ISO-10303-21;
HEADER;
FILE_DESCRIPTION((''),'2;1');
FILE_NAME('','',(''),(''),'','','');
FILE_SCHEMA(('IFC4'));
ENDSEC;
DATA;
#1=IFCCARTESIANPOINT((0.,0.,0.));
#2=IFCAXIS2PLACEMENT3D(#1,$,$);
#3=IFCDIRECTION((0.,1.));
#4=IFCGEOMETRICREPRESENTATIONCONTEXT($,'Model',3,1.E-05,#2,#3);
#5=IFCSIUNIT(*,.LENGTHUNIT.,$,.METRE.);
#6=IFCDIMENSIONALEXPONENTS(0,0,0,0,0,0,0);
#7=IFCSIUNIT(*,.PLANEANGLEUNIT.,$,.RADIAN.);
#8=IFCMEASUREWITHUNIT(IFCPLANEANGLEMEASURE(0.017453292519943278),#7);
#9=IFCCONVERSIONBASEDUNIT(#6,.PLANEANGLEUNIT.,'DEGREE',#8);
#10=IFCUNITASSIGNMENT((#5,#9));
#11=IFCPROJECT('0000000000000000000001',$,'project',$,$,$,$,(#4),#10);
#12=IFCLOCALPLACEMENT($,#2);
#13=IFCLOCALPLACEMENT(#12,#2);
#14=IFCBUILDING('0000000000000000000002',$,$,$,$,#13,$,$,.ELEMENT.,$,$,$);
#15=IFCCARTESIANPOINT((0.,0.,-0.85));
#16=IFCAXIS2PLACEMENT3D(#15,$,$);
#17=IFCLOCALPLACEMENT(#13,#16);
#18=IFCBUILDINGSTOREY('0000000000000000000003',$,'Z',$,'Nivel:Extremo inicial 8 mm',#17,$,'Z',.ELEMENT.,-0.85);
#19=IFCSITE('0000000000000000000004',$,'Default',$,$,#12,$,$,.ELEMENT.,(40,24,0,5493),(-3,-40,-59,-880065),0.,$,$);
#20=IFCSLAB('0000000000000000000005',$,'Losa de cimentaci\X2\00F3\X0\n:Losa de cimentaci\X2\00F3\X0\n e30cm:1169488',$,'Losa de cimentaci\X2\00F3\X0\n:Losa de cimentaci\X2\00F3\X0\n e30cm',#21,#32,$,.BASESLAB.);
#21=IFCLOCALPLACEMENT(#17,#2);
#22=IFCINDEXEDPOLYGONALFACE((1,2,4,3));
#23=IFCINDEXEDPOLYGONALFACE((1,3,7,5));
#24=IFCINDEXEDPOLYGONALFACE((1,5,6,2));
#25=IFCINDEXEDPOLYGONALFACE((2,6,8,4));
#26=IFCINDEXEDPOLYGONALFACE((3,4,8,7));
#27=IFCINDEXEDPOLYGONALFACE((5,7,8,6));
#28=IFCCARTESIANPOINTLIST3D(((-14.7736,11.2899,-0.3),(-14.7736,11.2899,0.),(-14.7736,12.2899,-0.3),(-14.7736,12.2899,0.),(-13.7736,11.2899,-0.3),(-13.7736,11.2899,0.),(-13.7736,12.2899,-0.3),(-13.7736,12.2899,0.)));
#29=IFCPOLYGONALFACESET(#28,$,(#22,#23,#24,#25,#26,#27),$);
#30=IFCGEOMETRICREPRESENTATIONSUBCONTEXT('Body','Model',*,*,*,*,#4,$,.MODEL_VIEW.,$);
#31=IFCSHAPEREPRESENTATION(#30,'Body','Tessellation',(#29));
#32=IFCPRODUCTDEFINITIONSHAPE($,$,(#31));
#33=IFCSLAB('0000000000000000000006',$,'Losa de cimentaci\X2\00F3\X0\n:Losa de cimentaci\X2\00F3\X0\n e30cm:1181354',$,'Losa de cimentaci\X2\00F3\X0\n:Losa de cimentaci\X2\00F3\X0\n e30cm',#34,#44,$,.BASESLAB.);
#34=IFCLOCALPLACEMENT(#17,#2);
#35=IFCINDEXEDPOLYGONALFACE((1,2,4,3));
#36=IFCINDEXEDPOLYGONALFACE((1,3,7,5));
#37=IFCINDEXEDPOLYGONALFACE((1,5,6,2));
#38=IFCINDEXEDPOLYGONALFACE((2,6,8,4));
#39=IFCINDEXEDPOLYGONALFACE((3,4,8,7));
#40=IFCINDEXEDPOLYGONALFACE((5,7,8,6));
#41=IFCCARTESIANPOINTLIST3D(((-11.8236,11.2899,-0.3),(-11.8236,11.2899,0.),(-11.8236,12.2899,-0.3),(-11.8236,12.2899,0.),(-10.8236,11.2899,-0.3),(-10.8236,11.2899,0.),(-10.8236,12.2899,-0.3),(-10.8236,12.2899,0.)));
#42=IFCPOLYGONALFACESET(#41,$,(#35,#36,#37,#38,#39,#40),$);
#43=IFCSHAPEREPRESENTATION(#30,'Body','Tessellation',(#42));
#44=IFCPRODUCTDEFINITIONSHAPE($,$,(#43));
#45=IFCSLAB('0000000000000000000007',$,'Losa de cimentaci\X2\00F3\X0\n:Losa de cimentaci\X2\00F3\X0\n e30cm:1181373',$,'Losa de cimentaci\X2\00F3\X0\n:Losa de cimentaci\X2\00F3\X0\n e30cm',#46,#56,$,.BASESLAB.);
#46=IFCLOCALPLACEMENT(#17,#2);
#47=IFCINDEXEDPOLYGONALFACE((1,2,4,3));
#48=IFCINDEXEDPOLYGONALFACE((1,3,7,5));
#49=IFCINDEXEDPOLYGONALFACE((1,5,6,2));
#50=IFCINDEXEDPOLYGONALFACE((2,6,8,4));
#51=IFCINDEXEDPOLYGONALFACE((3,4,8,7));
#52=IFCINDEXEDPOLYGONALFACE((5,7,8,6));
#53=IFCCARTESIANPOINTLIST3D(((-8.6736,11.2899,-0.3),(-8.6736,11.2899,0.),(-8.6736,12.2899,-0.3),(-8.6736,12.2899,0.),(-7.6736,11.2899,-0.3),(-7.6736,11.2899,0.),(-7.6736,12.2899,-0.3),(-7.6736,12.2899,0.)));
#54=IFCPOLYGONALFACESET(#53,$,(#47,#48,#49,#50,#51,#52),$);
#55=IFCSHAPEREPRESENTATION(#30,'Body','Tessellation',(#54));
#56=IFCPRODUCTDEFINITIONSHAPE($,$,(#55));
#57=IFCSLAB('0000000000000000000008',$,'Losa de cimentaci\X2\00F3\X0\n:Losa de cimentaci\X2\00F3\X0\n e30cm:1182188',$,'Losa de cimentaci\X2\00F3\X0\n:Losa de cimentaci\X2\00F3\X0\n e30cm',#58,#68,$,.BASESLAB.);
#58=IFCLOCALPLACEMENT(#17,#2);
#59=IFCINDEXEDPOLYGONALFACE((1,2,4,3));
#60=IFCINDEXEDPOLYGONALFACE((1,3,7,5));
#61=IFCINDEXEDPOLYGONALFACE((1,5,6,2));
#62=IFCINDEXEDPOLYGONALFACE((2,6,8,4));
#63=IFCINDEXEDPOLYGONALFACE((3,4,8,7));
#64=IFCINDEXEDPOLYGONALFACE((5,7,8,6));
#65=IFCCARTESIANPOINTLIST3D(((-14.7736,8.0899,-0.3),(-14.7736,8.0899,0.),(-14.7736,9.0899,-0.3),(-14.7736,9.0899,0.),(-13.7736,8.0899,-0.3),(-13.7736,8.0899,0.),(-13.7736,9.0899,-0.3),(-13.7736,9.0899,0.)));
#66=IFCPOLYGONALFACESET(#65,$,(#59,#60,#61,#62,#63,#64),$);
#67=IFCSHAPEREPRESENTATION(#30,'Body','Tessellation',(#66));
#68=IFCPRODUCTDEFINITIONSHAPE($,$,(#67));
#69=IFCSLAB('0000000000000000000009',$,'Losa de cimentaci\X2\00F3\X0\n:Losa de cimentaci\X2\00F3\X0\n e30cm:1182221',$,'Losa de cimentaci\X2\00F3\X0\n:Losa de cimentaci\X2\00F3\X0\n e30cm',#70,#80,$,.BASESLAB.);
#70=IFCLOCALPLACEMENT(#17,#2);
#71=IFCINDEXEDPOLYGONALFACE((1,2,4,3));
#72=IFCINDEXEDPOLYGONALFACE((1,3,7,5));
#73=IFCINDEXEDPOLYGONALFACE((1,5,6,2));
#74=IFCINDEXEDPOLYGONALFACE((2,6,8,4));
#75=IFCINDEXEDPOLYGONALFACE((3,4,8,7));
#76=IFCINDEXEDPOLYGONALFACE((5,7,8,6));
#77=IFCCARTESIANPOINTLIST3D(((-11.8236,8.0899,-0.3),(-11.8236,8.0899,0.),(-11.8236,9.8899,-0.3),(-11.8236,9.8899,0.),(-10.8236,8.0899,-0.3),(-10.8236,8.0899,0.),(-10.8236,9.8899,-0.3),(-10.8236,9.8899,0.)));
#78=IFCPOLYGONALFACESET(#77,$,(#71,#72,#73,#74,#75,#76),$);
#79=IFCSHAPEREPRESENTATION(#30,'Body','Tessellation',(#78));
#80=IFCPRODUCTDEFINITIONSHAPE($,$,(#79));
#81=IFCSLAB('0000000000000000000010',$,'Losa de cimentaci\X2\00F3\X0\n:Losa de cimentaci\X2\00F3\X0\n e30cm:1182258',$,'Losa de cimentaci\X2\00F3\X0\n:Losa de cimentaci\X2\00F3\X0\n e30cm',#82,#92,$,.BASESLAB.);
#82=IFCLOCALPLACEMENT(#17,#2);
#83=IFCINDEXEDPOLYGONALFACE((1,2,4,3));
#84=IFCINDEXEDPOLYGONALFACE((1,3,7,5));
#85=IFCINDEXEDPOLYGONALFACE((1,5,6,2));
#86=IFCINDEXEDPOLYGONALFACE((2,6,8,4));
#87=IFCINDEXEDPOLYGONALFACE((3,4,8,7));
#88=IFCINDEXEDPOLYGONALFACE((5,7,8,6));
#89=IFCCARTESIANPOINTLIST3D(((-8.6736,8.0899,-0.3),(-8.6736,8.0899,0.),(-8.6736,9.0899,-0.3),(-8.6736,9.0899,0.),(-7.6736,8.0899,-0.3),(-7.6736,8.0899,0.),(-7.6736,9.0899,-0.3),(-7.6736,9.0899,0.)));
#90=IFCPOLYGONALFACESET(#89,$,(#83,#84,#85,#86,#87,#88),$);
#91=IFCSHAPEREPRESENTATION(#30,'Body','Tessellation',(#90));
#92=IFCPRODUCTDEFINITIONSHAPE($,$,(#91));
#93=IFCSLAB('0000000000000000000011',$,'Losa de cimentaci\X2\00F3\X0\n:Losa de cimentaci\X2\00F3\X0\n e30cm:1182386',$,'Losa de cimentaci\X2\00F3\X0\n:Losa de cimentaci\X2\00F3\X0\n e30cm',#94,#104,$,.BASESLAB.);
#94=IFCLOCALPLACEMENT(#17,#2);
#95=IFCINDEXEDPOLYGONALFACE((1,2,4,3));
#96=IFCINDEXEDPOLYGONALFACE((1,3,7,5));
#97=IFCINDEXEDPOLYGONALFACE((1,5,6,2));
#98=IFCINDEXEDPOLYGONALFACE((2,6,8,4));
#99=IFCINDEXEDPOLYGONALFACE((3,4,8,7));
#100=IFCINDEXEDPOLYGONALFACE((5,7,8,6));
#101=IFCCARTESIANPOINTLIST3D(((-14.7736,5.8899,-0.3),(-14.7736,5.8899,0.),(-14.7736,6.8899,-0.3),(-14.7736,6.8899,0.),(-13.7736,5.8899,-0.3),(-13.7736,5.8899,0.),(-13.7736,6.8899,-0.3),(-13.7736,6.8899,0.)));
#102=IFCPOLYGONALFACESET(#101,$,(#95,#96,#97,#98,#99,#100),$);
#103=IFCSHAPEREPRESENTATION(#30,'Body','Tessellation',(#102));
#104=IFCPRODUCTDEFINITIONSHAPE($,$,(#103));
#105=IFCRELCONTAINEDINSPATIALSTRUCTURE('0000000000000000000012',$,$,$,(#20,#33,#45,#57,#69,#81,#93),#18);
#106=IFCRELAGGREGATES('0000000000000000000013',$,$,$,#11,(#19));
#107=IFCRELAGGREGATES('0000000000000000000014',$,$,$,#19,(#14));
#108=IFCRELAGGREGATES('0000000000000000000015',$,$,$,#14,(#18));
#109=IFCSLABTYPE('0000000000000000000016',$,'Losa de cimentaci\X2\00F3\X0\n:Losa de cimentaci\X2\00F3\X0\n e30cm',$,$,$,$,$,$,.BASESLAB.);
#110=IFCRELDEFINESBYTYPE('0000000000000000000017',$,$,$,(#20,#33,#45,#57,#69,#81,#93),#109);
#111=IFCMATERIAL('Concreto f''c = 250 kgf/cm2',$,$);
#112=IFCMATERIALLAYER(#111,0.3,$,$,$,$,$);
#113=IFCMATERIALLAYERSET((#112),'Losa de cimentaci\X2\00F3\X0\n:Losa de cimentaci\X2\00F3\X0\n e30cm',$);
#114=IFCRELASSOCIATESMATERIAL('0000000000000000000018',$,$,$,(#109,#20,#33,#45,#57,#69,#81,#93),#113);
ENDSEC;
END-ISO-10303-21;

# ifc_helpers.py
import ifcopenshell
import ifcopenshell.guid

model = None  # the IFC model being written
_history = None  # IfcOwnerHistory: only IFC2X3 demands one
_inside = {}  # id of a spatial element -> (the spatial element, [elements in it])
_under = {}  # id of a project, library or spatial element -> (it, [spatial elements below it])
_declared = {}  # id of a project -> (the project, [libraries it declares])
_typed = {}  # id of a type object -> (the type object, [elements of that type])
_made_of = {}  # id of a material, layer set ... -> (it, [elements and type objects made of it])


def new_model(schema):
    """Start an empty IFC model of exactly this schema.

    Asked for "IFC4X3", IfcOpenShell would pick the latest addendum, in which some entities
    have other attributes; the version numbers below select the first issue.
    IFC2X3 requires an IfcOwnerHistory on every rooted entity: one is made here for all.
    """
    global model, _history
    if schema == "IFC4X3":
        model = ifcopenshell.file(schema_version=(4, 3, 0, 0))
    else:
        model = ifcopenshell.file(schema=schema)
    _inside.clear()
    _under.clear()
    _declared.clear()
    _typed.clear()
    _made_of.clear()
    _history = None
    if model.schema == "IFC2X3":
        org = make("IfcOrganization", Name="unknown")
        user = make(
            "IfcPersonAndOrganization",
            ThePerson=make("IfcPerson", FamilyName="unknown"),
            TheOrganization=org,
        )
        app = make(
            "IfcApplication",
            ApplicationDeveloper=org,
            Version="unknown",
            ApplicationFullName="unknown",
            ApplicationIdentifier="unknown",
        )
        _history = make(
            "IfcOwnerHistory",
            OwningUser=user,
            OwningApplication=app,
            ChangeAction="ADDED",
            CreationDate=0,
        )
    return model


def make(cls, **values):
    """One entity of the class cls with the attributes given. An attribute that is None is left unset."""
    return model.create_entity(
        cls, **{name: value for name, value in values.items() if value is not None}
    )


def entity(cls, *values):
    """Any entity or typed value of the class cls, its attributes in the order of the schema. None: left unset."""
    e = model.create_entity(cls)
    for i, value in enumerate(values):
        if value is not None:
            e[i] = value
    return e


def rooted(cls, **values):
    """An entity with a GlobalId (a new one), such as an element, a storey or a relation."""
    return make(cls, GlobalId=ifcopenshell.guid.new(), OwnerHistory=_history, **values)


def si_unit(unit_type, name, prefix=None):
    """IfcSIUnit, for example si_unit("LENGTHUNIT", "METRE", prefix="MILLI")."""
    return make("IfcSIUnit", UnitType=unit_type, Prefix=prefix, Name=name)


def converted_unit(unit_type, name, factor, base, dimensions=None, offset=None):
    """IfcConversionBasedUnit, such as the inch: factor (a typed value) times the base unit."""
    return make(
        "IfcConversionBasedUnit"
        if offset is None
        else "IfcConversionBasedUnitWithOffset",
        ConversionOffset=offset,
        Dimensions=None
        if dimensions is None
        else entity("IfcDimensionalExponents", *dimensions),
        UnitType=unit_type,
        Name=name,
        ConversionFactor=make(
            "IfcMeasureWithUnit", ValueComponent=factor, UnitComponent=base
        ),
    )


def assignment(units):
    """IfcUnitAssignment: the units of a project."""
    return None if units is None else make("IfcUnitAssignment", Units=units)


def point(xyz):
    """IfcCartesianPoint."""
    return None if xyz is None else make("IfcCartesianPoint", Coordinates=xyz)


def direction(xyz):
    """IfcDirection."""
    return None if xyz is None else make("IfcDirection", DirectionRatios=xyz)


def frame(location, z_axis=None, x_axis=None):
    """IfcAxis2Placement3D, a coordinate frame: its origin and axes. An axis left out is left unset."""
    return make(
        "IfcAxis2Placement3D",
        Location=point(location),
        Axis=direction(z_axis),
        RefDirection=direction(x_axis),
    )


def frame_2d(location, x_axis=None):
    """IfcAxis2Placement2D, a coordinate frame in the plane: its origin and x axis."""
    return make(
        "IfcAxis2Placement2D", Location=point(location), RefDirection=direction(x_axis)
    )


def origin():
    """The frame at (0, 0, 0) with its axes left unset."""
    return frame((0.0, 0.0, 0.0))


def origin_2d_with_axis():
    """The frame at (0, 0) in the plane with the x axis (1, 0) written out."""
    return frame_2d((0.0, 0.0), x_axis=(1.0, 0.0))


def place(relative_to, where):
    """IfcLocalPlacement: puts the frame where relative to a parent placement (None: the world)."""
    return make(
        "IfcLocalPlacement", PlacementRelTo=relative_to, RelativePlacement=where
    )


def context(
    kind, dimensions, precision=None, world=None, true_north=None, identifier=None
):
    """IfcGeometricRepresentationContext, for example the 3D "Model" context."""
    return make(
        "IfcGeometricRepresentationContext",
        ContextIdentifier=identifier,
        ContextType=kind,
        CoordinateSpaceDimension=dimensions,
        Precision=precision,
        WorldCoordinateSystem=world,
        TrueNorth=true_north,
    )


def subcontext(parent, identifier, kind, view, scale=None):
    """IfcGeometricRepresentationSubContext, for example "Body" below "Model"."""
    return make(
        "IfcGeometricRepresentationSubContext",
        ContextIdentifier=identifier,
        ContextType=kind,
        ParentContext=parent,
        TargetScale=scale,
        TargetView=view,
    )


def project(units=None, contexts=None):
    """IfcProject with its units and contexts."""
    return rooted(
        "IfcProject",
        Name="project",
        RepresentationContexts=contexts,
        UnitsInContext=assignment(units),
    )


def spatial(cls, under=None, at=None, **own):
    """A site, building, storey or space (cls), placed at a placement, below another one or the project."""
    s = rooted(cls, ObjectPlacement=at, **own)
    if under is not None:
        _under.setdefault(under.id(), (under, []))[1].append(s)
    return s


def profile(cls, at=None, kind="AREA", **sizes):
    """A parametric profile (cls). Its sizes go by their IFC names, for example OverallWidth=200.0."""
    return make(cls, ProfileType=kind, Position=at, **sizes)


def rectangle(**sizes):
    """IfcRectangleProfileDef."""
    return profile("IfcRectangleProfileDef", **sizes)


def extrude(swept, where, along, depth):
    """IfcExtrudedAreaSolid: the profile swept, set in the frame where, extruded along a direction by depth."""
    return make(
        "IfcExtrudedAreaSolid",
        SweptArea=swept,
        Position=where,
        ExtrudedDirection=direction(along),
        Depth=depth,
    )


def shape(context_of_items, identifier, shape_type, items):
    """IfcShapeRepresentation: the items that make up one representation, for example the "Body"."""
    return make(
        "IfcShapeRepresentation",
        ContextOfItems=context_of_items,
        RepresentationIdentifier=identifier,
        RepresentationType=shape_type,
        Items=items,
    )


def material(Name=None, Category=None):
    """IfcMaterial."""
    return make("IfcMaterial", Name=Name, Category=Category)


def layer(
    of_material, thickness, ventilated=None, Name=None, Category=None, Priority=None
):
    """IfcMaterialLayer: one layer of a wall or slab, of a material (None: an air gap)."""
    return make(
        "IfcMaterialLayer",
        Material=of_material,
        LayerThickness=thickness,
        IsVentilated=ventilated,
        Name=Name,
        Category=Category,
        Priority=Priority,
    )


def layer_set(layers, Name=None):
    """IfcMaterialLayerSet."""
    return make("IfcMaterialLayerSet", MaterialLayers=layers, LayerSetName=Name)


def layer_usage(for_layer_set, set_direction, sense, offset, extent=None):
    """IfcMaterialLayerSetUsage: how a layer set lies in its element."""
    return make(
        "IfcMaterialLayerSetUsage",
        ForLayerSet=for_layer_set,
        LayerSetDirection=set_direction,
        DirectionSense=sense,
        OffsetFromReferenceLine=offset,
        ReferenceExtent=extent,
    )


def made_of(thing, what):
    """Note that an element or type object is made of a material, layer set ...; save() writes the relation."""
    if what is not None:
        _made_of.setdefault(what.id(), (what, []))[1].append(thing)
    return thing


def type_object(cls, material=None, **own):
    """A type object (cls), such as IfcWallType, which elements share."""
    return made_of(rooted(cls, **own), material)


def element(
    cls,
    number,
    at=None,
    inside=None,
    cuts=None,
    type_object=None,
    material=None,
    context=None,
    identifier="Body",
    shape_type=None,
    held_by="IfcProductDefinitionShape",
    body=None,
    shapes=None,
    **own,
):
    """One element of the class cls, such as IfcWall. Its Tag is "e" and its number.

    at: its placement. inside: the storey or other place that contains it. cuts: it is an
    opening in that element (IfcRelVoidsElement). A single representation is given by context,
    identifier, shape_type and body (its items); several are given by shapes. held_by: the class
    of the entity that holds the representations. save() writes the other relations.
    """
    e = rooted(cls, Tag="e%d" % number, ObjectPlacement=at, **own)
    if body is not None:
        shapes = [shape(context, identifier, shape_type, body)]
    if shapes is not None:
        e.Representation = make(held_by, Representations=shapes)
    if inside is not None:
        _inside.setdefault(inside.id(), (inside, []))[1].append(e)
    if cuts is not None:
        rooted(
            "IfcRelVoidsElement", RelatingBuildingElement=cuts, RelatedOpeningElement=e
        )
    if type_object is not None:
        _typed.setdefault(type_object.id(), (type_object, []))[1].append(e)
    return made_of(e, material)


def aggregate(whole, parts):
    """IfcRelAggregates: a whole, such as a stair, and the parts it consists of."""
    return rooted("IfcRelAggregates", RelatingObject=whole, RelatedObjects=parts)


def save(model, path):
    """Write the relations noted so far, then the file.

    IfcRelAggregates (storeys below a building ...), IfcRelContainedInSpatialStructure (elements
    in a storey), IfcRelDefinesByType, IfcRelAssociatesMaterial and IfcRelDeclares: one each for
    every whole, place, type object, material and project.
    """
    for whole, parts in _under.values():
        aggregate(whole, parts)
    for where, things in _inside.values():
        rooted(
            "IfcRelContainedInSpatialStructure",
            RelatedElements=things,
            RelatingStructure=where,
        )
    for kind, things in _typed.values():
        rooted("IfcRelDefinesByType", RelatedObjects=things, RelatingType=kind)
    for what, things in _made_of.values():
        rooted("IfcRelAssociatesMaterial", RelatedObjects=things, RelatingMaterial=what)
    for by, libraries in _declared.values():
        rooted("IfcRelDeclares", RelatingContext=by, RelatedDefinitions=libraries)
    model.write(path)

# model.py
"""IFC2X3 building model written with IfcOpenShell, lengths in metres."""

from ifc_helpers import new_model, entity, si_unit, converted_unit, direction, frame, frame_2d, origin, origin_2d_with_axis, place, context, subcontext, project, spatial, rectangle, extrude, material, layer, layer_set, layer_usage, type_object, element, save


model = new_model("IFC2X3")

# Units and contexts
model_context = context("Model", 3, precision=1e-05, world=origin(), true_north=direction((0.0, 1.0)))
body_context = subcontext(model_context, "Body", "Model", "MODEL_VIEW")
ifc_project = project(units=[si_unit("LENGTHUNIT", "METRE"), converted_unit("PLANEANGLEUNIT", "DEGREE", entity("IfcPlaneAngleMeasure", 0.017453292519943278), si_unit("PLANEANGLEUNIT", "RADIAN"), dimensions=[0, 0, 0, 0, 0, 0, 0])], contexts=[model_context])

# Site, building, storey
site_placement = place(None, origin())
site = spatial("IfcSite", under=ifc_project, at=site_placement, Name="Default", CompositionType="ELEMENT", RefLatitude=(40, 24, 0, 5493), RefLongitude=(-3, -40, -59, -880065), RefElevation=0.0)
building_placement = place(site_placement, origin())
building = spatial("IfcBuilding", under=site, at=building_placement, CompositionType="ELEMENT")
storey_placement = place(building_placement, frame((0.0, 0.0, -0.85)))
storey = spatial("IfcBuildingStorey", under=building, at=storey_placement, Name="Z", ObjectType="Nivel:Extremo inicial 8 mm", LongName="Z", CompositionType="ELEMENT", Elevation=-0.85)

# Slabs
ifc_material_1 = material(Name="Concreto f'c = 250 kgf/cm2")
ifc_layer = layer(ifc_material_1, 0.3)
ifc_layer_set = layer_set([ifc_layer], Name="Losa de cimentación:Losa de cimentación e30cm")
ifc_layer_usage_1 = layer_usage(ifc_layer_set, "AXIS3", "POSITIVE", 0.0)
slab_type = type_object("IfcSlabType", Name="Losa de cimentación:Losa de cimentación e30cm", PredefinedType="BASESLAB", material=ifc_layer_set)
slab_1_placement = place(storey_placement, origin())
element("IfcSlab", 1, at=slab_1_placement, inside=storey, type_object=slab_type, material=ifc_layer_usage_1, Name="Losa de cimentación:Losa de cimentación e30cm:1169488", ObjectType="Losa de cimentación:Losa de cimentación e30cm", PredefinedType="BASESLAB", context=body_context, shape_type="SweptSolid", body=[
    extrude(rectangle(XDim=1.0, YDim=1.0, at=origin_2d_with_axis()), frame((-14.2736, 11.7899, 0.0), z_axis=(0.0, 0.0, -1.0), x_axis=(0.0, 1.0, 0.0)), (0.0, 0.0, 1.0), 0.3),
])
ifc_layer_usage_2 = layer_usage(ifc_layer_set, "AXIS3", "POSITIVE", 0.0)
slab_2_placement = place(storey_placement, origin())
element("IfcSlab", 2, at=slab_2_placement, inside=storey, type_object=slab_type, material=ifc_layer_usage_2, Name="Losa de cimentación:Losa de cimentación e30cm:1181354", ObjectType="Losa de cimentación:Losa de cimentación e30cm", PredefinedType="BASESLAB", context=body_context, shape_type="SweptSolid", body=[
    extrude(rectangle(XDim=1.0, YDim=1.0, at=origin_2d_with_axis()), frame((-11.3236, 11.7899, 0.0), z_axis=(0.0, 0.0, -1.0), x_axis=(0.0, 1.0, 0.0)), (0.0, 0.0, 1.0), 0.3),
])
ifc_layer_usage_3 = layer_usage(ifc_layer_set, "AXIS3", "POSITIVE", 0.0)
slab_3_placement = place(storey_placement, origin())
element("IfcSlab", 3, at=slab_3_placement, inside=storey, type_object=slab_type, material=ifc_layer_usage_3, Name="Losa de cimentación:Losa de cimentación e30cm:1181373", ObjectType="Losa de cimentación:Losa de cimentación e30cm", PredefinedType="BASESLAB", context=body_context, shape_type="SweptSolid", body=[
    extrude(rectangle(XDim=1.0, YDim=1.0, at=origin_2d_with_axis()), frame((-8.1736, 11.7899, 0.0), z_axis=(0.0, 0.0, -1.0), x_axis=(0.0, 1.0, 0.0)), (0.0, 0.0, 1.0), 0.3),
])
ifc_layer_usage_4 = layer_usage(ifc_layer_set, "AXIS3", "POSITIVE", 0.0)
slab_4_placement = place(storey_placement, origin())
element("IfcSlab", 4, at=slab_4_placement, inside=storey, type_object=slab_type, material=ifc_layer_usage_4, Name="Losa de cimentación:Losa de cimentación e30cm:1182188", ObjectType="Losa de cimentación:Losa de cimentación e30cm", PredefinedType="BASESLAB", context=body_context, shape_type="SweptSolid", body=[
    extrude(rectangle(XDim=1.0, YDim=1.0, at=origin_2d_with_axis()), frame((-14.2736, 8.5899, 0.0), z_axis=(0.0, 0.0, -1.0), x_axis=(0.0, 1.0, 0.0)), (0.0, 0.0, 1.0), 0.3),
])
ifc_layer_usage_5 = layer_usage(ifc_layer_set, "AXIS3", "POSITIVE", 0.0)
slab_5_placement = place(storey_placement, origin())
element("IfcSlab", 5, at=slab_5_placement, inside=storey, type_object=slab_type, material=ifc_layer_usage_5, Name="Losa de cimentación:Losa de cimentación e30cm:1182221", ObjectType="Losa de cimentación:Losa de cimentación e30cm", PredefinedType="BASESLAB", context=body_context, shape_type="SweptSolid", body=[
    extrude(rectangle(XDim=1.8, YDim=1.0, at=frame_2d((0.0, 0.0), x_axis=(1.0, 0.0))), frame((-11.3236, 8.9899, 0.0), z_axis=(0.0, 0.0, -1.0), x_axis=(0.0, 1.0, 0.0)), (0.0, 0.0, 1.0), 0.3),
])
ifc_layer_usage_6 = layer_usage(ifc_layer_set, "AXIS3", "POSITIVE", 0.0)
slab_6_placement = place(storey_placement, origin())
element("IfcSlab", 6, at=slab_6_placement, inside=storey, type_object=slab_type, material=ifc_layer_usage_6, Name="Losa de cimentación:Losa de cimentación e30cm:1182258", ObjectType="Losa de cimentación:Losa de cimentación e30cm", PredefinedType="BASESLAB", context=body_context, shape_type="SweptSolid", body=[
    extrude(rectangle(XDim=1.0, YDim=1.0, at=origin_2d_with_axis()), frame((-8.1736, 8.5899, 0.0), z_axis=(0.0, 0.0, -1.0), x_axis=(0.0, 1.0, 0.0)), (0.0, 0.0, 1.0), 0.3),
])
ifc_layer_usage_7 = layer_usage(ifc_layer_set, "AXIS3", "POSITIVE", 0.0)
slab_7_placement = place(storey_placement, origin())
element("IfcSlab", 7, at=slab_7_placement, inside=storey, type_object=slab_type, material=ifc_layer_usage_7, Name="Losa de cimentación:Losa de cimentación e30cm:1182386", ObjectType="Losa de cimentación:Losa de cimentación e30cm", PredefinedType="BASESLAB", context=body_context, shape_type="SweptSolid", body=[
    extrude(rectangle(XDim=1.0, YDim=1.0, at=origin_2d_with_axis()), frame((-14.2736, 6.3899, 0.0), z_axis=(0.0, 0.0, -1.0), x_axis=(0.0, 1.0, 0.0)), (0.0, 0.0, 1.0), 0.3),
])

save(model, "model.ifc")
